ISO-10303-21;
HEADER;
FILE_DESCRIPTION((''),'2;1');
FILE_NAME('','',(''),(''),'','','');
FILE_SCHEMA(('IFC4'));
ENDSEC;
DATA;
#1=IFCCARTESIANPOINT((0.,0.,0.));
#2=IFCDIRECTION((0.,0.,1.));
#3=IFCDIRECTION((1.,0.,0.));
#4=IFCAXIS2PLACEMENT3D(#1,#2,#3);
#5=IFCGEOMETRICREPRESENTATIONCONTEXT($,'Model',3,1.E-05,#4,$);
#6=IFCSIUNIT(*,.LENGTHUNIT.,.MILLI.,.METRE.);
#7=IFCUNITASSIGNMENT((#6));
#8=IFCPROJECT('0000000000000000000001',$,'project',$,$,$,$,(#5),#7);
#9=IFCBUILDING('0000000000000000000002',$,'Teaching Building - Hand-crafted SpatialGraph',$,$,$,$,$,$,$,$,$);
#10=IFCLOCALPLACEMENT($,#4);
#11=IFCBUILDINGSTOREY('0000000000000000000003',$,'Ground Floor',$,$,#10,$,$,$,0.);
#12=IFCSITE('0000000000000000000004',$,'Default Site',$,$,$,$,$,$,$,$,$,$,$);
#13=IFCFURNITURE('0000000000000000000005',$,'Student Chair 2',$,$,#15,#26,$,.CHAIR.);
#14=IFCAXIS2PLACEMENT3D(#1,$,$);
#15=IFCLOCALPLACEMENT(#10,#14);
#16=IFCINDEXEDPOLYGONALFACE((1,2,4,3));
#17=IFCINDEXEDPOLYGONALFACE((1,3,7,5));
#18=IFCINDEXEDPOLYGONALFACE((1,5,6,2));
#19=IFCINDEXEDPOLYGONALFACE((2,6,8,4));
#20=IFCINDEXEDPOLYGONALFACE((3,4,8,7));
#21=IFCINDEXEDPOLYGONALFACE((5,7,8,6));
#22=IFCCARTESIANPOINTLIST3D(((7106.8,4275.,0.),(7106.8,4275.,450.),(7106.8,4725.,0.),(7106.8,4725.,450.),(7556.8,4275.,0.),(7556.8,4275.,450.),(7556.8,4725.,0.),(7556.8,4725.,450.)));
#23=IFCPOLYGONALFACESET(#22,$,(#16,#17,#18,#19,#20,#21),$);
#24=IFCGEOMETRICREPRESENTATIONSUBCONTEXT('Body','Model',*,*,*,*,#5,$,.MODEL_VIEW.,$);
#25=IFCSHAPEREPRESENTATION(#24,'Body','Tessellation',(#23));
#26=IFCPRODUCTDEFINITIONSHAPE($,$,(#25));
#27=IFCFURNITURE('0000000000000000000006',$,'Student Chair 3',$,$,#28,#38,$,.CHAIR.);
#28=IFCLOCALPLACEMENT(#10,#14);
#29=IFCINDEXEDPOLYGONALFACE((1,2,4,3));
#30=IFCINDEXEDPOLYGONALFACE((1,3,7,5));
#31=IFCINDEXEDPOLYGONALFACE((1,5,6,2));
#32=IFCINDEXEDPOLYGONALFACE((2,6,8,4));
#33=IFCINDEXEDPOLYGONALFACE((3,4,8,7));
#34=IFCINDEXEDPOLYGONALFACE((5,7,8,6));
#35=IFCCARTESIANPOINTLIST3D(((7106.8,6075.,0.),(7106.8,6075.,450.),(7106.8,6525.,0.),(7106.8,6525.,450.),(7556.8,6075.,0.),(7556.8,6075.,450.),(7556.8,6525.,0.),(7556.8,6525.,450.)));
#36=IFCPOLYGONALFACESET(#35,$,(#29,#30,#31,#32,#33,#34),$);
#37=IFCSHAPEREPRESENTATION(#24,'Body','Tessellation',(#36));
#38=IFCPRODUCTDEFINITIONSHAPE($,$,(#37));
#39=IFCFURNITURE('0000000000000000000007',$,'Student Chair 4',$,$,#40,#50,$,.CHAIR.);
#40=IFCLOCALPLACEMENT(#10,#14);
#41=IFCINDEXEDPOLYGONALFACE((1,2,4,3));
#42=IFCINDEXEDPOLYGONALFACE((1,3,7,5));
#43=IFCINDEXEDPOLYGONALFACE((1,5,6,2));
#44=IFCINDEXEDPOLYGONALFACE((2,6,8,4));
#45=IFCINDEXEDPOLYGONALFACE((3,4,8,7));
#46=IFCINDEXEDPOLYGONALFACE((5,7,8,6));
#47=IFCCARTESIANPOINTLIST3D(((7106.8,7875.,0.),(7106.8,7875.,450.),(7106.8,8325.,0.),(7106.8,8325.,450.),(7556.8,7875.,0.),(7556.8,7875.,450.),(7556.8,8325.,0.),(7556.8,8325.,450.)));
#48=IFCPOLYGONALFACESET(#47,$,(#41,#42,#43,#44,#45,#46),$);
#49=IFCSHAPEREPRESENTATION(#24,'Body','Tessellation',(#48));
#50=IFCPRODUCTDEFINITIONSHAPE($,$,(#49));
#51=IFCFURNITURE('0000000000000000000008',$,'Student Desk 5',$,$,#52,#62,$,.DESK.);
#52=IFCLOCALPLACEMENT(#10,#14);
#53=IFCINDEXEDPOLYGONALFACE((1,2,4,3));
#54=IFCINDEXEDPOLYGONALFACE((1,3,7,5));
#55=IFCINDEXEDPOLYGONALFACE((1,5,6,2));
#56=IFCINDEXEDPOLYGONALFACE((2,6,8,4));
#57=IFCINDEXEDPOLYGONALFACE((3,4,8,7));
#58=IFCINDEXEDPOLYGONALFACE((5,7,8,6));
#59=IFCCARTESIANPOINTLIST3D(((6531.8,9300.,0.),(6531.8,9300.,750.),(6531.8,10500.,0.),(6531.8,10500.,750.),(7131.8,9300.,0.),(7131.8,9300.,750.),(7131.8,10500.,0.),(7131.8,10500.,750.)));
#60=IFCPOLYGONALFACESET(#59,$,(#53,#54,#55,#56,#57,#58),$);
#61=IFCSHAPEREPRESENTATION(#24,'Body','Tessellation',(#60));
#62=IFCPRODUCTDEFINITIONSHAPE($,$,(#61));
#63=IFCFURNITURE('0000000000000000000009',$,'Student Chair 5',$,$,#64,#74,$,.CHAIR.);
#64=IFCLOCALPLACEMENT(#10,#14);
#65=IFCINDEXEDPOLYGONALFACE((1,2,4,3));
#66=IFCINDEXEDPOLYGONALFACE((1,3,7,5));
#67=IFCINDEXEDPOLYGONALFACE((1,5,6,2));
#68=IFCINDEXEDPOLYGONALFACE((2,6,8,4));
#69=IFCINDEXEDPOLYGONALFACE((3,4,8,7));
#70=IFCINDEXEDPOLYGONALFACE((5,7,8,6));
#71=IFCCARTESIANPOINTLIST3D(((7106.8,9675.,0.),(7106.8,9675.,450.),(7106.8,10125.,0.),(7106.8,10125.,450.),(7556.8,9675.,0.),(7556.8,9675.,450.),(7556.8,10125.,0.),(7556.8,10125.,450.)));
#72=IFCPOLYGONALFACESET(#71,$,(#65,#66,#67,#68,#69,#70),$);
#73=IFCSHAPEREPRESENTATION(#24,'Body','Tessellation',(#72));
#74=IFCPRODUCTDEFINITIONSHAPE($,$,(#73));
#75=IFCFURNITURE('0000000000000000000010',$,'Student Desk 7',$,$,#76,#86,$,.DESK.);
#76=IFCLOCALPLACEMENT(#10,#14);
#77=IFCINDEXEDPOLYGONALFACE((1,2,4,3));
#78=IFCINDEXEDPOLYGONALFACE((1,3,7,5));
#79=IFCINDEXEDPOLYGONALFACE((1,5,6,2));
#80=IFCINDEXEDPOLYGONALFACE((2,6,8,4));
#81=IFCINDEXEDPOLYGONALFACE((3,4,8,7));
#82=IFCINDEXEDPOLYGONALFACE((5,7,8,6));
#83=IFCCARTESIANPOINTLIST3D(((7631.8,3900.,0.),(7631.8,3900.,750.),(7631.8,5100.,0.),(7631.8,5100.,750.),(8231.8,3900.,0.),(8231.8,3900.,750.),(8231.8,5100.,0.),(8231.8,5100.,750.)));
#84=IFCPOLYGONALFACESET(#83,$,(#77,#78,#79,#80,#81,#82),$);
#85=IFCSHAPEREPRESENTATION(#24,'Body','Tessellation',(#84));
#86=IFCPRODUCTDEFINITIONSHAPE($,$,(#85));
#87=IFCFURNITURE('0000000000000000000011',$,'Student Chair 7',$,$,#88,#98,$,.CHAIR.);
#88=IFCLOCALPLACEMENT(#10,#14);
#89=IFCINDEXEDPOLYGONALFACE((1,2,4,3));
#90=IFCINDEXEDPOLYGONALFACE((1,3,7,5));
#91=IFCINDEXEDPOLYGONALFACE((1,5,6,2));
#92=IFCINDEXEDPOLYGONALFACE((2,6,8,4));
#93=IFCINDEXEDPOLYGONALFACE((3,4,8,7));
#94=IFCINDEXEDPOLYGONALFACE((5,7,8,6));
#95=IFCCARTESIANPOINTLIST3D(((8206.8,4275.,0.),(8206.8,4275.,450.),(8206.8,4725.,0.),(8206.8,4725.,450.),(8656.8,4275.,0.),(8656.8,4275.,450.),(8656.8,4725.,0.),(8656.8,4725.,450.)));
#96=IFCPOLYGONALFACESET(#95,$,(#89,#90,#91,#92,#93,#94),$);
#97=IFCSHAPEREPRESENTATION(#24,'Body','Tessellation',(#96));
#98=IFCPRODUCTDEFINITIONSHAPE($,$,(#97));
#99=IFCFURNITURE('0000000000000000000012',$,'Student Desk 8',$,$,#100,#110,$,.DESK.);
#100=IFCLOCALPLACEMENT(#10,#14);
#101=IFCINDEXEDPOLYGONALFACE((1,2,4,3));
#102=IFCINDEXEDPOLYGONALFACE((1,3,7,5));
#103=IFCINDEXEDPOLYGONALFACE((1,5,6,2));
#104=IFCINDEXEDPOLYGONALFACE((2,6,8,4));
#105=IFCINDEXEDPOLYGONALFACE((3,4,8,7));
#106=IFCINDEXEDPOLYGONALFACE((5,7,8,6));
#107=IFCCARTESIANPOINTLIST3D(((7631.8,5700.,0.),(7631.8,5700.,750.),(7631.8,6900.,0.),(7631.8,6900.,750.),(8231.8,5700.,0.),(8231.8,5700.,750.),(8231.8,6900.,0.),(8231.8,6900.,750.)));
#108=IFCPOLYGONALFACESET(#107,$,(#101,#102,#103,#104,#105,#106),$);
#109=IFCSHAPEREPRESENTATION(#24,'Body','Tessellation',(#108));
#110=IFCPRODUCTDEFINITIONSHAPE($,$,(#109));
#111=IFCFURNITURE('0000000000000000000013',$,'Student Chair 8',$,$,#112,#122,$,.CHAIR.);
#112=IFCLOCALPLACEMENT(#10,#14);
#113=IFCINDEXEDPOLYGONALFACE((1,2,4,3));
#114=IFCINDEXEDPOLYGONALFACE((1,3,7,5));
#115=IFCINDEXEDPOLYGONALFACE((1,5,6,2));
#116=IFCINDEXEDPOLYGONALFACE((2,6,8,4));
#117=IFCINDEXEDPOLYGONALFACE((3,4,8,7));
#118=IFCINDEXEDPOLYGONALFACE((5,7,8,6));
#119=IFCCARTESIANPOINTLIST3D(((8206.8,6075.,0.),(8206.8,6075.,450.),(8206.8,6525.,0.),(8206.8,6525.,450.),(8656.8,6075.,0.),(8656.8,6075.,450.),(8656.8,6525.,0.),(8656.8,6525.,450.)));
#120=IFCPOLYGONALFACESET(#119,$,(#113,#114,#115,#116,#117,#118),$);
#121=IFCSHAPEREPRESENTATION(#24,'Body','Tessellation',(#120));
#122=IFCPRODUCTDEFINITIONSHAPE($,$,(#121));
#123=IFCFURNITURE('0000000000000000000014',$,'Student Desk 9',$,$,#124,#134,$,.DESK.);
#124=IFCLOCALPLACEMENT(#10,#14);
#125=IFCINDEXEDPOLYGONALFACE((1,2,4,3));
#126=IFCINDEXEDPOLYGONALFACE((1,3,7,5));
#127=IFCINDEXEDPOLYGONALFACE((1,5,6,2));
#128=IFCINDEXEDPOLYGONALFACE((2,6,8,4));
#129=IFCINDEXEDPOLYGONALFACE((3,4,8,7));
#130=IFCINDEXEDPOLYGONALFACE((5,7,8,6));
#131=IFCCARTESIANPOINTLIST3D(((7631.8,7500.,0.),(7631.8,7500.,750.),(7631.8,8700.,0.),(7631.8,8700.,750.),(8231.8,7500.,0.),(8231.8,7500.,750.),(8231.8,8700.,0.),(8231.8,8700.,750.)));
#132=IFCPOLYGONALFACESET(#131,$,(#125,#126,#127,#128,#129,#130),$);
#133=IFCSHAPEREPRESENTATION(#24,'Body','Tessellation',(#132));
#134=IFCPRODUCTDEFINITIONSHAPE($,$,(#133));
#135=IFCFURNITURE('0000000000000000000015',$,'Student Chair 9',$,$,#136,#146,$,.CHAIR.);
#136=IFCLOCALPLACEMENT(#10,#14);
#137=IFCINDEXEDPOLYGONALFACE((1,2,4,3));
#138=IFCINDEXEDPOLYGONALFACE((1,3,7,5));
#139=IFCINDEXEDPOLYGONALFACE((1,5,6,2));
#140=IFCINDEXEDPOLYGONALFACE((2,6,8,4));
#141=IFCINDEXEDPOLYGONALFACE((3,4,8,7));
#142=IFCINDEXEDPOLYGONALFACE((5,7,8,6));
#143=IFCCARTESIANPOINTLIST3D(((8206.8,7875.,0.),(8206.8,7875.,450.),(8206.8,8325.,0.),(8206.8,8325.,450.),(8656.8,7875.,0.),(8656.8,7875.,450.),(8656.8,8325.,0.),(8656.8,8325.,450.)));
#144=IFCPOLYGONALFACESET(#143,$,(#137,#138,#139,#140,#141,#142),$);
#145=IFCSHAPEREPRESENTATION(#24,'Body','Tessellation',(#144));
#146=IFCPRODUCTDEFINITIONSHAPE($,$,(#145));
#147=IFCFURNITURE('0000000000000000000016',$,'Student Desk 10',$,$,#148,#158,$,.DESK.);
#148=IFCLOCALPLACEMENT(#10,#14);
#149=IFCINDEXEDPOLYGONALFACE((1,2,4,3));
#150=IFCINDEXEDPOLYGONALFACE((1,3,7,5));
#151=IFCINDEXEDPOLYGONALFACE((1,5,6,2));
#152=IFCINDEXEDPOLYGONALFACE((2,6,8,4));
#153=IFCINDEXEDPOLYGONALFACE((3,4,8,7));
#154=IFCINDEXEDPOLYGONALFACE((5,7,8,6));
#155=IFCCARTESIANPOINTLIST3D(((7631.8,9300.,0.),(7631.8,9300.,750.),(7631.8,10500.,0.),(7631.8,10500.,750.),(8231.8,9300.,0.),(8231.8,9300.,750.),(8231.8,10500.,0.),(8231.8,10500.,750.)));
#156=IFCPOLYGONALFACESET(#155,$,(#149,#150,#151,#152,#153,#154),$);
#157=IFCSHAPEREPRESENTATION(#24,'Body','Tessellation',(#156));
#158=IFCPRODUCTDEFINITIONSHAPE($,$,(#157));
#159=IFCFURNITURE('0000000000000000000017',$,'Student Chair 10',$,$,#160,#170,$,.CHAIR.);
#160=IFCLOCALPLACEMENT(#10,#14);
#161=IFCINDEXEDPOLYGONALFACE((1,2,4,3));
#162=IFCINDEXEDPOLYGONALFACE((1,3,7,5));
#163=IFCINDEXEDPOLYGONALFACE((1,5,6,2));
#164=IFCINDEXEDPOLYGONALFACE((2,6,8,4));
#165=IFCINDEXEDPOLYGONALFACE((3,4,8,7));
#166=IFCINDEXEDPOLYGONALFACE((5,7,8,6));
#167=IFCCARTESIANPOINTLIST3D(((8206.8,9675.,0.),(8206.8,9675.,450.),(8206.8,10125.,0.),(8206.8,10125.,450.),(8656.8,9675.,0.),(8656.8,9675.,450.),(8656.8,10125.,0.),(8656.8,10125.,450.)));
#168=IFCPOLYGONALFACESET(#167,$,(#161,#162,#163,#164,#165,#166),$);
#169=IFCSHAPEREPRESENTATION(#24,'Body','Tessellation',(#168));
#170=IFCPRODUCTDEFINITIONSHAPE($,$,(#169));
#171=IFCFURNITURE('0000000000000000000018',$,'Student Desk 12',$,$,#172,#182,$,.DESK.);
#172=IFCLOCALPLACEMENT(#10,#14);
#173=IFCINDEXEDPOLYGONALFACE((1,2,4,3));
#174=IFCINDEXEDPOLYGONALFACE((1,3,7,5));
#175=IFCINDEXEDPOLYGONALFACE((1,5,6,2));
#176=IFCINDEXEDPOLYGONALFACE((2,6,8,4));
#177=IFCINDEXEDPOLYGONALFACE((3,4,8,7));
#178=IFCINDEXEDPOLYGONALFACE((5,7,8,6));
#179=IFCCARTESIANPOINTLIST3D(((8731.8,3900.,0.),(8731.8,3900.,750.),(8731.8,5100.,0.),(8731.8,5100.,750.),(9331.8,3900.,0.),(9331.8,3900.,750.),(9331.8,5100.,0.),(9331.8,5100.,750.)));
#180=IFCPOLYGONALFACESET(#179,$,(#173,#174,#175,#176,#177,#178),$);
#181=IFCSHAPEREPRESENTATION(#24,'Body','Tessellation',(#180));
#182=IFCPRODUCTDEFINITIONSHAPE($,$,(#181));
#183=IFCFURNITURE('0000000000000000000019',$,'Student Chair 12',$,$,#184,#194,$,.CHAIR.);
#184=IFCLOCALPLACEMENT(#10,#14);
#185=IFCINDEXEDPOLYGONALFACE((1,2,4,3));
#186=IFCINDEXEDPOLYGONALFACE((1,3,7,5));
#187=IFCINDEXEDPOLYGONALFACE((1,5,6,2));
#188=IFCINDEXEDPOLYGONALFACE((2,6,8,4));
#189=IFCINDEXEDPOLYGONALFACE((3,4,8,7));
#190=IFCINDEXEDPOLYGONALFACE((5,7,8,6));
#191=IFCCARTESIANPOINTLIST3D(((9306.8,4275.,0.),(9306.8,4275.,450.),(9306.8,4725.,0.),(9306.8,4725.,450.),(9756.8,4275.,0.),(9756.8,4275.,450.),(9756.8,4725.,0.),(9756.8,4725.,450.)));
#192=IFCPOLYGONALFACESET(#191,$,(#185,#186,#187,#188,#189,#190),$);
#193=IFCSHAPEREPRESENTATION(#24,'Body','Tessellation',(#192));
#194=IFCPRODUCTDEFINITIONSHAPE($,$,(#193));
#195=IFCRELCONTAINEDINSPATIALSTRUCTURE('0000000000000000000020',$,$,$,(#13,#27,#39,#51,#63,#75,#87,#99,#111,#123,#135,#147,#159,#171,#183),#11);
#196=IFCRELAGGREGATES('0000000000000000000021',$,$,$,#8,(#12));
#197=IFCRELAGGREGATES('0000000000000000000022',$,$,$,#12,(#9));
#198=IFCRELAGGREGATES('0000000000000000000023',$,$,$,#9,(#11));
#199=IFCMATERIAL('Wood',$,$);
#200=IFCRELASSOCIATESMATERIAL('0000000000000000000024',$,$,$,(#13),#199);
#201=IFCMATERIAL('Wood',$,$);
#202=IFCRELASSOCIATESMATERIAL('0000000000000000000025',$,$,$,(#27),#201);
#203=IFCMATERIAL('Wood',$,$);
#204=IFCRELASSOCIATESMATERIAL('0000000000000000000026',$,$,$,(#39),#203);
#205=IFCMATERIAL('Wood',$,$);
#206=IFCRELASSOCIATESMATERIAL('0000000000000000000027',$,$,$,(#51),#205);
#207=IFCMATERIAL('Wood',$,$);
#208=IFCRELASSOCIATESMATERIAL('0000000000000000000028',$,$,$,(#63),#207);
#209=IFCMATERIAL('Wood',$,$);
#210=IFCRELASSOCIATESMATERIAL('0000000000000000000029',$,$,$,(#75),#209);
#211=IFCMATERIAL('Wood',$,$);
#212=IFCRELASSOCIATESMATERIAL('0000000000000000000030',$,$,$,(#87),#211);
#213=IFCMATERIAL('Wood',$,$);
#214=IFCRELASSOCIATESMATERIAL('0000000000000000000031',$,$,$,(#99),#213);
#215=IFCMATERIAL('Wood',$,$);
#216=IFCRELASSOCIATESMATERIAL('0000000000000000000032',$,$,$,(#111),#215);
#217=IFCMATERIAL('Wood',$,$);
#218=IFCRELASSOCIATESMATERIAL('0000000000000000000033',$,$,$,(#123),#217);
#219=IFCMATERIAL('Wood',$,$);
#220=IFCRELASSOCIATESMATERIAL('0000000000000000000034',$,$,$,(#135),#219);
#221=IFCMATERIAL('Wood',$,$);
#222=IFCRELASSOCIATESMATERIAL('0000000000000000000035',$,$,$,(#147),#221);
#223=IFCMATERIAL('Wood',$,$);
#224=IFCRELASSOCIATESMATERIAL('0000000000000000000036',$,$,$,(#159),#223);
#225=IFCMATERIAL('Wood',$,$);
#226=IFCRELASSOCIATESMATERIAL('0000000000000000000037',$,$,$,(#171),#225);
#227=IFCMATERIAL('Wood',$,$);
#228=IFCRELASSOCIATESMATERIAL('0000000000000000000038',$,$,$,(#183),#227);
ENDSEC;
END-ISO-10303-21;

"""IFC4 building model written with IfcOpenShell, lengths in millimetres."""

from ifc_helpers import new_model, si_unit, frame, origin_with_axes, origin_2d, place, context, subcontext, project, spatial, rectangle, extrude, material, element, save


model = new_model("IFC4")

# Units and contexts
model_context = context("Model", 3, precision=1e-05, world=origin_with_axes())
body_context = subcontext(model_context, "Body", "Model", "MODEL_VIEW")
ifc_project = project(units=[si_unit("LENGTHUNIT", "METRE", prefix="MILLI")], contexts=[model_context])

# Site, building, storey
site = spatial("IfcSite", under=ifc_project, Name="Default Site")
building = spatial("IfcBuilding", under=site, Name="Teaching Building - Hand-crafted SpatialGraph")
storey_placement = place(None, origin_with_axes())
storey = spatial("IfcBuildingStorey", under=building, at=storey_placement, Name="Ground Floor", Elevation=0.0)

# Furniture
ifc_material_1 = material(Name="Wood")
furniture_1_placement = place(storey_placement, frame((7331.8, 4500.0, 0.0), z_axis=(0.0, 0.0, 1.0), x_axis=(1.0, 0.0, 0.0)))
element("IfcFurniture", 1, at=furniture_1_placement, inside=storey, material=ifc_material_1, Name="Student Chair 2", PredefinedType="CHAIR", context=body_context, shape_type="SweptSolid", body=[
    extrude(rectangle(XDim=450.0, YDim=450.0, at=origin_2d()), origin_with_axes(), (0.0, 0.0, 1.0), 450.0),
])
ifc_material_2 = material(Name="Wood")
furniture_2_placement = place(storey_placement, frame((7331.8, 6300.0, 0.0), z_axis=(0.0, 0.0, 1.0), x_axis=(1.0, 0.0, 0.0)))
element("IfcFurniture", 2, at=furniture_2_placement, inside=storey, material=ifc_material_2, Name="Student Chair 3", PredefinedType="CHAIR", context=body_context, shape_type="SweptSolid", body=[
    extrude(rectangle(XDim=450.0, YDim=450.0, at=origin_2d()), origin_with_axes(), (0.0, 0.0, 1.0), 450.0),
])
ifc_material_3 = material(Name="Wood")
furniture_3_placement = place(storey_placement, frame((7331.8, 8100.0, 0.0), z_axis=(0.0, 0.0, 1.0), x_axis=(1.0, 0.0, 0.0)))
element("IfcFurniture", 3, at=furniture_3_placement, inside=storey, material=ifc_material_3, Name="Student Chair 4", PredefinedType="CHAIR", context=body_context, shape_type="SweptSolid", body=[
    extrude(rectangle(XDim=450.0, YDim=450.0, at=origin_2d()), origin_with_axes(), (0.0, 0.0, 1.0), 450.0),
])
ifc_material_4 = material(Name="Wood")
furniture_4_placement = place(storey_placement, frame((6831.8, 9900.0, 0.0), z_axis=(0.0, 0.0, 1.0), x_axis=(0.0, 1.0, 0.0)))
element("IfcFurniture", 4, at=furniture_4_placement, inside=storey, material=ifc_material_4, Name="Student Desk 5", PredefinedType="DESK", context=body_context, shape_type="SweptSolid", body=[
    extrude(rectangle(XDim=1200.0, YDim=600.0, at=origin_2d()), origin_with_axes(), (0.0, 0.0, 1.0), 750.0),
])
ifc_material_5 = material(Name="Wood")
furniture_5_placement = place(storey_placement, frame((7331.8, 9900.0, 0.0), z_axis=(0.0, 0.0, 1.0), x_axis=(1.0, 0.0, 0.0)))
element("IfcFurniture", 5, at=furniture_5_placement, inside=storey, material=ifc_material_5, Name="Student Chair 5", PredefinedType="CHAIR", context=body_context, shape_type="SweptSolid", body=[
    extrude(rectangle(XDim=450.0, YDim=450.0, at=origin_2d()), origin_with_axes(), (0.0, 0.0, 1.0), 450.0),
])
ifc_material_6 = material(Name="Wood")
furniture_6_placement = place(storey_placement, frame((7931.8, 4500.0, 0.0), z_axis=(0.0, 0.0, 1.0), x_axis=(0.0, 1.0, 0.0)))
element("IfcFurniture", 6, at=furniture_6_placement, inside=storey, material=ifc_material_6, Name="Student Desk 7", PredefinedType="DESK", context=body_context, shape_type="SweptSolid", body=[
    extrude(rectangle(XDim=1200.0, YDim=600.0, at=origin_2d()), origin_with_axes(), (0.0, 0.0, 1.0), 750.0),
])
ifc_material_7 = material(Name="Wood")
furniture_7_placement = place(storey_placement, frame((8431.8, 4500.0, 0.0), z_axis=(0.0, 0.0, 1.0), x_axis=(1.0, 0.0, 0.0)))
element("IfcFurniture", 7, at=furniture_7_placement, inside=storey, material=ifc_material_7, Name="Student Chair 7", PredefinedType="CHAIR", context=body_context, shape_type="SweptSolid", body=[
    extrude(rectangle(XDim=450.0, YDim=450.0, at=origin_2d()), origin_with_axes(), (0.0, 0.0, 1.0), 450.0),
])
ifc_material_8 = material(Name="Wood")
furniture_8_placement = place(storey_placement, frame((7931.8, 6300.0, 0.0), z_axis=(0.0, 0.0, 1.0), x_axis=(0.0, 1.0, 0.0)))
element("IfcFurniture", 8, at=furniture_8_placement, inside=storey, material=ifc_material_8, Name="Student Desk 8", PredefinedType="DESK", context=body_context, shape_type="SweptSolid", body=[
    extrude(rectangle(XDim=1200.0, YDim=600.0, at=origin_2d()), origin_with_axes(), (0.0, 0.0, 1.0), 750.0),
])
ifc_material_9 = material(Name="Wood")
furniture_9_placement = place(storey_placement, frame((8431.8, 6300.0, 0.0), z_axis=(0.0, 0.0, 1.0), x_axis=(1.0, 0.0, 0.0)))
element("IfcFurniture", 9, at=furniture_9_placement, inside=storey, material=ifc_material_9, Name="Student Chair 8", PredefinedType="CHAIR", context=body_context, shape_type="SweptSolid", body=[
    extrude(rectangle(XDim=450.0, YDim=450.0, at=origin_2d()), origin_with_axes(), (0.0, 0.0, 1.0), 450.0),
])
ifc_material_10 = material(Name="Wood")
furniture_10_placement = place(storey_placement, frame((7931.8, 8100.0, 0.0), z_axis=(0.0, 0.0, 1.0), x_axis=(0.0, 1.0, 0.0)))
element("IfcFurniture", 10, at=furniture_10_placement, inside=storey, material=ifc_material_10, Name="Student Desk 9", PredefinedType="DESK", context=body_context, shape_type="SweptSolid", body=[
    extrude(rectangle(XDim=1200.0, YDim=600.0, at=origin_2d()), origin_with_axes(), (0.0, 0.0, 1.0), 750.0),
])
ifc_material_11 = material(Name="Wood")
furniture_11_placement = place(storey_placement, frame((8431.8, 8100.0, 0.0), z_axis=(0.0, 0.0, 1.0), x_axis=(1.0, 0.0, 0.0)))
element("IfcFurniture", 11, at=furniture_11_placement, inside=storey, material=ifc_material_11, Name="Student Chair 9", PredefinedType="CHAIR", context=body_context, shape_type="SweptSolid", body=[
    extrude(rectangle(XDim=450.0, YDim=450.0, at=origin_2d()), origin_with_axes(), (0.0, 0.0, 1.0), 450.0),
])
ifc_material_12 = material(Name="Wood")
furniture_12_placement = place(storey_placement, frame((7931.8, 9900.0, 0.0), z_axis=(0.0, 0.0, 1.0), x_axis=(0.0, 1.0, 0.0)))
element("IfcFurniture", 12, at=furniture_12_placement, inside=storey, material=ifc_material_12, Name="Student Desk 10", PredefinedType="DESK", context=body_context, shape_type="SweptSolid", body=[
    extrude(rectangle(XDim=1200.0, YDim=600.0, at=origin_2d()), origin_with_axes(), (0.0, 0.0, 1.0), 750.0),
])
ifc_material_13 = material(Name="Wood")
furniture_13_placement = place(storey_placement, frame((8431.8, 9900.0, 0.0), z_axis=(0.0, 0.0, 1.0), x_axis=(1.0, 0.0, 0.0)))
element("IfcFurniture", 13, at=furniture_13_placement, inside=storey, material=ifc_material_13, Name="Student Chair 10", PredefinedType="CHAIR", context=body_context, shape_type="SweptSolid", body=[
    extrude(rectangle(XDim=450.0, YDim=450.0, at=origin_2d()), origin_with_axes(), (0.0, 0.0, 1.0), 450.0),
])
ifc_material_14 = material(Name="Wood")
furniture_14_placement = place(storey_placement, frame((9031.8, 4500.0, 0.0), z_axis=(0.0, 0.0, 1.0), x_axis=(0.0, 1.0, 0.0)))
element("IfcFurniture", 14, at=furniture_14_placement, inside=storey, material=ifc_material_14, Name="Student Desk 12", PredefinedType="DESK", context=body_context, shape_type="SweptSolid", body=[
    extrude(rectangle(XDim=1200.0, YDim=600.0, at=origin_2d()), origin_with_axes(), (0.0, 0.0, 1.0), 750.0),
])
ifc_material_15 = material(Name="Wood")
furniture_15_placement = place(storey_placement, frame((9531.8, 4500.0, 0.0), z_axis=(0.0, 0.0, 1.0), x_axis=(1.0, 0.0, 0.0)))
element("IfcFurniture", 15, at=furniture_15_placement, inside=storey, material=ifc_material_15, Name="Student Chair 12", PredefinedType="CHAIR", context=body_context, shape_type="SweptSolid", body=[
    extrude(rectangle(XDim=450.0, YDim=450.0, at=origin_2d()), origin_with_axes(), (0.0, 0.0, 1.0), 450.0),
])

save(model, "model.ifc")
